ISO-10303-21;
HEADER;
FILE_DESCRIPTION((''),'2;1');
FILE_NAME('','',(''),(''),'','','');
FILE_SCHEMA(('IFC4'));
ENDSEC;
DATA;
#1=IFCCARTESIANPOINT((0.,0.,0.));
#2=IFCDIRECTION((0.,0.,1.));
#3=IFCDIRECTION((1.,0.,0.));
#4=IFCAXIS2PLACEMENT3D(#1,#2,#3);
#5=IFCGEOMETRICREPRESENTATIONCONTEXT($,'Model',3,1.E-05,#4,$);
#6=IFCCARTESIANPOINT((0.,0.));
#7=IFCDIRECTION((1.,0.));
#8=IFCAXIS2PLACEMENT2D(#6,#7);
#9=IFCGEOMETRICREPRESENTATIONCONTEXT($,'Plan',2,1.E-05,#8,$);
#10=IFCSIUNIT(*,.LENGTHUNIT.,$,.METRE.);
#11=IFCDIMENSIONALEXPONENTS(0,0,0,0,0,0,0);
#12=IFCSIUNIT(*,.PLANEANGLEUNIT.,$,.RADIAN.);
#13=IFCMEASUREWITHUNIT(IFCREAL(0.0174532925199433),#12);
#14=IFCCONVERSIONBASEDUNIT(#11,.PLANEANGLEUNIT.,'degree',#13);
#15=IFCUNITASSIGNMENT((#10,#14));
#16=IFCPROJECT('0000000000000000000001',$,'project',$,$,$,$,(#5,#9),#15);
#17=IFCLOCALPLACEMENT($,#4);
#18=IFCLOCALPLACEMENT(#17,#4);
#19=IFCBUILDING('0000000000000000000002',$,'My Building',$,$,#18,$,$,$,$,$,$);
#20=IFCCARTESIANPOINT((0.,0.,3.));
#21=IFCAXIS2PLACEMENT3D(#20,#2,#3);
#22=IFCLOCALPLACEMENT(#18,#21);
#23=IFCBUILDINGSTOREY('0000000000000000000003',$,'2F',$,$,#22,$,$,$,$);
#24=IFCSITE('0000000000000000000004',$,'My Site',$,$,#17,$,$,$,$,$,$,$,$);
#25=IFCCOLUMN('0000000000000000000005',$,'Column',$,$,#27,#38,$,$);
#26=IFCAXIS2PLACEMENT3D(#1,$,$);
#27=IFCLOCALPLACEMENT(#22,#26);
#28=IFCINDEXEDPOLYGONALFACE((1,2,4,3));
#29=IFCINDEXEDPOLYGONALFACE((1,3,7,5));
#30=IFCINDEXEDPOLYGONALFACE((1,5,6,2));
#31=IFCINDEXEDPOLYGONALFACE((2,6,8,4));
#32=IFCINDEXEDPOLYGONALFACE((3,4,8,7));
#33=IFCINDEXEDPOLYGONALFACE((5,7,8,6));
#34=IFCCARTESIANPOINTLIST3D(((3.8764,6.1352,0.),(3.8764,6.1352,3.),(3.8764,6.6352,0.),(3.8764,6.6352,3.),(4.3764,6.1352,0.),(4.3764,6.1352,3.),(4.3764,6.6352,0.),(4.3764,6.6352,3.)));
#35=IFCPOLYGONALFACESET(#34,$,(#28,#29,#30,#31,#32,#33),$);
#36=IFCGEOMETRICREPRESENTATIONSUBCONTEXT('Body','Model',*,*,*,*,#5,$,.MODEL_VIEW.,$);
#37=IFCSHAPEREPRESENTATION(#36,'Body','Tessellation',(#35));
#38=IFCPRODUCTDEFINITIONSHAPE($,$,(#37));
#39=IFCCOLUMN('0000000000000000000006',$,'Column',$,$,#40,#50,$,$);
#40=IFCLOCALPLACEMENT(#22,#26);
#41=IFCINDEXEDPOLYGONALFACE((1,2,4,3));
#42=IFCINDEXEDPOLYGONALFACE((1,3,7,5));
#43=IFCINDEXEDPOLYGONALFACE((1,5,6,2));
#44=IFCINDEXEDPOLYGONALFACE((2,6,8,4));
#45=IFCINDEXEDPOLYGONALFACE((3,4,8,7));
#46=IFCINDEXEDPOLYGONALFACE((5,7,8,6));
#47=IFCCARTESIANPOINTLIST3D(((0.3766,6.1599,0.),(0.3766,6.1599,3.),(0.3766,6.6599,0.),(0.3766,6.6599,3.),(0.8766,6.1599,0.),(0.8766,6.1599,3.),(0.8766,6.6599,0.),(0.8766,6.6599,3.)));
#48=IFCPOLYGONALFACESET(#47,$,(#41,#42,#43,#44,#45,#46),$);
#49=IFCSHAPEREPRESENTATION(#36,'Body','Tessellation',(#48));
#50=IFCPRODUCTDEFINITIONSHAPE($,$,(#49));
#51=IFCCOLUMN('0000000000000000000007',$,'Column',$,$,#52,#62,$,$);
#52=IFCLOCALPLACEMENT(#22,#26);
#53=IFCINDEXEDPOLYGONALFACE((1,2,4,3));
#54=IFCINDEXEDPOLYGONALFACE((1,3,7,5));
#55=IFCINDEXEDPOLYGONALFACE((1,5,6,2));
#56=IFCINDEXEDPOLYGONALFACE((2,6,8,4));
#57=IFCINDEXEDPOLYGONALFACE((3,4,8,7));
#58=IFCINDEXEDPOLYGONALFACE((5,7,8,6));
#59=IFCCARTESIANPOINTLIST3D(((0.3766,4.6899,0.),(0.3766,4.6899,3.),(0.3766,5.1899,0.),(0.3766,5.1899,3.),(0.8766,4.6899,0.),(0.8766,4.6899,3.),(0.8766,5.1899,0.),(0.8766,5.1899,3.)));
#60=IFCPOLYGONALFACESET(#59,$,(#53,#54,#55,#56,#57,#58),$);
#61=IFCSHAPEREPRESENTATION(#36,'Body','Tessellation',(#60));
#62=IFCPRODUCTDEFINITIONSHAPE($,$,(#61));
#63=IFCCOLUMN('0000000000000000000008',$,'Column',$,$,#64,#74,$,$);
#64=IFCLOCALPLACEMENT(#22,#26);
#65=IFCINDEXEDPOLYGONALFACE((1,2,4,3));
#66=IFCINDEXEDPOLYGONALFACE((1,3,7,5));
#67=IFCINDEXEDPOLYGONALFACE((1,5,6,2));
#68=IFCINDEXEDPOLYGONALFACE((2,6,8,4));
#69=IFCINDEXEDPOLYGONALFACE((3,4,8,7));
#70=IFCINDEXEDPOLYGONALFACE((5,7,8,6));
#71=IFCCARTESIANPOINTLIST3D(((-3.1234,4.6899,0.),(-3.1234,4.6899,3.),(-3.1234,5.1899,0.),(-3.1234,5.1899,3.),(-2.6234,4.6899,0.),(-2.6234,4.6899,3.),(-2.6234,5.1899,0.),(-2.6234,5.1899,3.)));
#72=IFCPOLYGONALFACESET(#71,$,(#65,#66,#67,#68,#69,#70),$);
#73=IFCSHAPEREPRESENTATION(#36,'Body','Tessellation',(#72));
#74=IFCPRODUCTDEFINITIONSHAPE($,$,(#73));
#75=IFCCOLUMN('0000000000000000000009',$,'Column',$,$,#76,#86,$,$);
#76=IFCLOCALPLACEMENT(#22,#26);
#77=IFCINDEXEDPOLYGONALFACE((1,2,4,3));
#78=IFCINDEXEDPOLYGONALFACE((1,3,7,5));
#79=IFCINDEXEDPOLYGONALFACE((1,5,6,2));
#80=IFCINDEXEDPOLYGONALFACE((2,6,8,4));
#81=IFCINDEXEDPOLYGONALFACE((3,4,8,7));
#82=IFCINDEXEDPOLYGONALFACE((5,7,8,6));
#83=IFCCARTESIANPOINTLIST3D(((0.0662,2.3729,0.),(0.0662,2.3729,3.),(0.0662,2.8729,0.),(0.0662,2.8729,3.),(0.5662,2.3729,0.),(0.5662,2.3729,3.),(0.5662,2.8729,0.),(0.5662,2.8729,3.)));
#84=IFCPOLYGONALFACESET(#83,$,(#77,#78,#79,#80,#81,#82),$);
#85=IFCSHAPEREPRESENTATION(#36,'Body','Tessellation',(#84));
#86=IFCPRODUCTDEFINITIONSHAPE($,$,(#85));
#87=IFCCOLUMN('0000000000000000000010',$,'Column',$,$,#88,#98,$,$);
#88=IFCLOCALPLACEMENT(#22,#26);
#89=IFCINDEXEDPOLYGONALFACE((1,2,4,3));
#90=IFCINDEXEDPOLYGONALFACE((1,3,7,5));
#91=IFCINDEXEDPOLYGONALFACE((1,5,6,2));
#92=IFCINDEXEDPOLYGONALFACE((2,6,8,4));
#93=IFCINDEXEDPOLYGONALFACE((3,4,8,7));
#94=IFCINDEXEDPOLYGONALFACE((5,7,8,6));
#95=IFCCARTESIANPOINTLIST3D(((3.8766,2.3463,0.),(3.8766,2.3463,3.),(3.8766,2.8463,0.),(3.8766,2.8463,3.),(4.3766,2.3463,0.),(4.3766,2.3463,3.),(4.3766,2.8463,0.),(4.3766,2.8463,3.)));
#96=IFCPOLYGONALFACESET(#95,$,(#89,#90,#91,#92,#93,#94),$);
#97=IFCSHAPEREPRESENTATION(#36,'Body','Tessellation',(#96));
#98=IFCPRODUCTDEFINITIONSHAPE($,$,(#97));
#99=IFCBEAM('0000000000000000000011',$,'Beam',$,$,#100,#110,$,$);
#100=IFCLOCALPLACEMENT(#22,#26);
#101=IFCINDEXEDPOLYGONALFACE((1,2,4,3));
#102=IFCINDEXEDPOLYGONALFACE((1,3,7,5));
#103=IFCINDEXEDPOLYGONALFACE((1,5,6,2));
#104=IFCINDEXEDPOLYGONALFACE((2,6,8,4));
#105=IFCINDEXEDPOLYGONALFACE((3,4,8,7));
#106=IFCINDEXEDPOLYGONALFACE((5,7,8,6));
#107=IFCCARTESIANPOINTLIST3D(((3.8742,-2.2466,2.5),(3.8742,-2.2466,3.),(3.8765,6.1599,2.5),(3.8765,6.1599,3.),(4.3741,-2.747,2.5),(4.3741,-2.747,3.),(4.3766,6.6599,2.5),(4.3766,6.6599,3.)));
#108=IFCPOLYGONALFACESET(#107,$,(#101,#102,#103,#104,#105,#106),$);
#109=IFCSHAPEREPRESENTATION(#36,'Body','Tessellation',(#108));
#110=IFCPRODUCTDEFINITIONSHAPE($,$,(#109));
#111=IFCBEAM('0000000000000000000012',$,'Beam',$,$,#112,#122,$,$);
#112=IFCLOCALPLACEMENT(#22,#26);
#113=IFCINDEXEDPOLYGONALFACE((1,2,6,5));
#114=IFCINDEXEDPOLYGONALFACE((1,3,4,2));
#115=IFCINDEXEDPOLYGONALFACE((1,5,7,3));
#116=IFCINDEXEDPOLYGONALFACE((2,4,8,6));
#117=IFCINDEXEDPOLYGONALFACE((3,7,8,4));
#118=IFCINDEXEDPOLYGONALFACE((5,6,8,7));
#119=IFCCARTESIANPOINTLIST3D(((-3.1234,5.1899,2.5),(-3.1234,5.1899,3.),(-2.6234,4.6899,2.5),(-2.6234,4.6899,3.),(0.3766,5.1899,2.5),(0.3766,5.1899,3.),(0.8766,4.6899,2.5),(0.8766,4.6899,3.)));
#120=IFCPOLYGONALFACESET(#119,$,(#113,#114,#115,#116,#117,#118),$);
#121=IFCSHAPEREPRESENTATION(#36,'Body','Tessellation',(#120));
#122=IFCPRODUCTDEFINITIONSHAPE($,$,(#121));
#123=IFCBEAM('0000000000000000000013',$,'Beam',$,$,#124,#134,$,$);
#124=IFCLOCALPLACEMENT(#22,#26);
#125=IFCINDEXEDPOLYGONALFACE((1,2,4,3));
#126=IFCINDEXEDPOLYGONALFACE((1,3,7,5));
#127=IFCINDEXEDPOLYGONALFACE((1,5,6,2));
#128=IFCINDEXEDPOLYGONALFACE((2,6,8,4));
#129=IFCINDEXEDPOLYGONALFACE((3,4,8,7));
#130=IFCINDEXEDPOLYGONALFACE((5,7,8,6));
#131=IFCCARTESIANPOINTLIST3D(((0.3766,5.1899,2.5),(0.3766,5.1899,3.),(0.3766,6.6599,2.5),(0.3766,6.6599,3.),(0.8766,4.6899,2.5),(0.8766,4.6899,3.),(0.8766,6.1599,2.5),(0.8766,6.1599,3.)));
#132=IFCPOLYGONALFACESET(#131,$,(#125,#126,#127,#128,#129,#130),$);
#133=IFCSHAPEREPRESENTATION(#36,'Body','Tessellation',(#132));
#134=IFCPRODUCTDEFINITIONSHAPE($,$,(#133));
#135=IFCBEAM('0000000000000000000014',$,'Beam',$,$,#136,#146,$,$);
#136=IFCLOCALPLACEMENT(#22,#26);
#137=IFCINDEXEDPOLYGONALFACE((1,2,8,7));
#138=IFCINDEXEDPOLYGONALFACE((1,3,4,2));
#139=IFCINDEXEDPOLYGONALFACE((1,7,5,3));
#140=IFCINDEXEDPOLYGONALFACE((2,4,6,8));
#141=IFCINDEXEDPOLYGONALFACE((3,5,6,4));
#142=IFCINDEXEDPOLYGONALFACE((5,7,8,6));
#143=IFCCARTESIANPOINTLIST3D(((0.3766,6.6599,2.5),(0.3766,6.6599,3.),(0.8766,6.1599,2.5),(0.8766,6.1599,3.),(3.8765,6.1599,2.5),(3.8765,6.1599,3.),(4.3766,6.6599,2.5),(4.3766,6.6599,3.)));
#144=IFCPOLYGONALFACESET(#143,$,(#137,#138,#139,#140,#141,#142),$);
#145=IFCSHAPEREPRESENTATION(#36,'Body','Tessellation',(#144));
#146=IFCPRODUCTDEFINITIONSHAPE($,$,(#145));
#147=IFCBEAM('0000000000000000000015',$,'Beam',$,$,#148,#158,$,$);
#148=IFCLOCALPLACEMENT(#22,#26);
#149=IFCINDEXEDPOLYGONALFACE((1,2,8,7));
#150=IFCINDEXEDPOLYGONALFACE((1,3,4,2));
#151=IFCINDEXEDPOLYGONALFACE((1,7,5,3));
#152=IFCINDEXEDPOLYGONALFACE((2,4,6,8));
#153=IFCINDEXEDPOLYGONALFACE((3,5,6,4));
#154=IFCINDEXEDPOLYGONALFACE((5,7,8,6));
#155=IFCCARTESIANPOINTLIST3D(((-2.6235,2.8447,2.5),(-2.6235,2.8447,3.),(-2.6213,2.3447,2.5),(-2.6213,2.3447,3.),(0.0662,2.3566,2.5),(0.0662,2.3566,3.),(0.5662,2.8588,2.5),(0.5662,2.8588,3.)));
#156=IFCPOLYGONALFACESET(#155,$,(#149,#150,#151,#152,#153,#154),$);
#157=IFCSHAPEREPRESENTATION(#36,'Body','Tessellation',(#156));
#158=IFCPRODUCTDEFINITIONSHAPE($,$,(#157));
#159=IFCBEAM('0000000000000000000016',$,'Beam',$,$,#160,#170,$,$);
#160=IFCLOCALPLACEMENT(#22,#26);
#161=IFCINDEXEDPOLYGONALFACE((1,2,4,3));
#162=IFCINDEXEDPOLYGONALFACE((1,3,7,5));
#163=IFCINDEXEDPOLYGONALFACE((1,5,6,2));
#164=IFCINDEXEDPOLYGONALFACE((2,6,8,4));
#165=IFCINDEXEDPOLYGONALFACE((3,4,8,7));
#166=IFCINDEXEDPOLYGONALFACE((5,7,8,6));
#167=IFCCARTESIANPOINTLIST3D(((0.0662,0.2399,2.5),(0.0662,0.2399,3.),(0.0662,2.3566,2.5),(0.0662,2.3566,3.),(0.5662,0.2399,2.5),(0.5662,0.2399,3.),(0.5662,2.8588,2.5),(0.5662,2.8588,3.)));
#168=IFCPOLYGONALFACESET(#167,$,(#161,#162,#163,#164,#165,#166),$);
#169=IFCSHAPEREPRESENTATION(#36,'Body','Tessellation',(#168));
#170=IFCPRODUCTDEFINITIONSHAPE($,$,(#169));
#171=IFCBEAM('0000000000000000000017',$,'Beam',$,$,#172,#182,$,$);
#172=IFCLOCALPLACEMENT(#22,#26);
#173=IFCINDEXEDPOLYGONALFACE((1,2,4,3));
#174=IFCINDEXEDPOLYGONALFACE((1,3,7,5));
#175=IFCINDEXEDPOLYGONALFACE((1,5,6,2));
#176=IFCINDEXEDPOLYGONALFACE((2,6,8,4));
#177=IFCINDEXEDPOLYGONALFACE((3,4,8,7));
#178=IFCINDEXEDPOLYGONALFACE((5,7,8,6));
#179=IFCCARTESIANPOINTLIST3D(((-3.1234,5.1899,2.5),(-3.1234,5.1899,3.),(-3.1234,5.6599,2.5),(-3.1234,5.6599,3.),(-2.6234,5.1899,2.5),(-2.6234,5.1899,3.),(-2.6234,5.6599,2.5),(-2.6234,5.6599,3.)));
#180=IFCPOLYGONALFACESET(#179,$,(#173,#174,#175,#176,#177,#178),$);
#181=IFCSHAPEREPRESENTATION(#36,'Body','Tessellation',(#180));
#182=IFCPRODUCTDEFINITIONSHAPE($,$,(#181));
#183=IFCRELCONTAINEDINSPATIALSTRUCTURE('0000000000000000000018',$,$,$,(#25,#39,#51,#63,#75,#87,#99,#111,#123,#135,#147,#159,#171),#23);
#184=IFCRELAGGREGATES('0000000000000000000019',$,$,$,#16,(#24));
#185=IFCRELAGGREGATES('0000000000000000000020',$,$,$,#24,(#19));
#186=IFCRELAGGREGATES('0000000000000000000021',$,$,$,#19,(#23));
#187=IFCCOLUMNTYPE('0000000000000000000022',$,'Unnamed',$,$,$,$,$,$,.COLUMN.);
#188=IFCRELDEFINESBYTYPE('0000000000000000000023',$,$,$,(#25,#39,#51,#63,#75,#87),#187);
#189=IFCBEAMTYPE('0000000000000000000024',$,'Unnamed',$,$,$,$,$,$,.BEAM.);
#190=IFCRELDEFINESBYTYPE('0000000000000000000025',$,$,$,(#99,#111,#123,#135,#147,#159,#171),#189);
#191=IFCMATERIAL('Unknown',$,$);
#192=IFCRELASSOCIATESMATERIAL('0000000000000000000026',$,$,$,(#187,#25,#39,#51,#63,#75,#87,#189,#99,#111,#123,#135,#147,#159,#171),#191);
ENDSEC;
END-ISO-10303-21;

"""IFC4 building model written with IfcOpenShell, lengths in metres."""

from ifc_helpers import new_model, entity, si_unit, converted_unit, frame, origin_with_axes, origin_2d_with_axis, place, context, subcontext, project, spatial, rectangle, extrude, clip, halfspace, material, material_profile, profile_set, profile_usage, type_object, element, save


model = new_model("IFC4")

# Units and contexts
model_context = context("Model", 3, precision=1e-05, world=origin_with_axes())
plan_context = context("Plan", 2, precision=1e-05, world=origin_2d_with_axis())
body_context_1 = subcontext(model_context, "Body", "Model", "MODEL_VIEW")
ifc_project = project(units=[si_unit("LENGTHUNIT", "METRE"), converted_unit("PLANEANGLEUNIT", "degree", entity("IfcReal", 0.0174532925199433), si_unit("PLANEANGLEUNIT", "RADIAN"), dimensions=[0, 0, 0, 0, 0, 0, 0])], contexts=[model_context, plan_context])

# Site, building, storey
site_placement = place(None, origin_with_axes())
site = spatial("IfcSite", under=ifc_project, at=site_placement, Name="My Site")
building_placement = place(site_placement, origin_with_axes())
building = spatial("IfcBuilding", under=site, at=building_placement, Name="My Building")
storey_placement = place(building_placement, frame((0.0, 0.0, 3.0), z_axis=(0.0, 0.0, 1.0), x_axis=(1.0, 0.0, 0.0)))
storey = spatial("IfcBuildingStorey", under=building, at=storey_placement, Name="2F")

# Columns
ifc_material = material(Name="Unknown")
ifc_material_profile_1 = material_profile(ifc_material, rectangle(XDim=0.5, YDim=0.5))
ifc_profile_set_1 = profile_set([ifc_material_profile_1])
ifc_profile_usage_1 = profile_usage(ifc_profile_set_1, cardinal=1)
column_type = type_object("IfcColumnType", Name="Unnamed", PredefinedType="COLUMN", material=ifc_profile_set_1)
column_1_placement = place(storey_placement, frame((4.3764, 6.1352, 0.0), z_axis=(0.0, 0.0, 1.0), x_axis=(1.0, 0.0, 0.0)))
element("IfcColumn", 1, at=column_1_placement, inside=storey, type_object=column_type, material=ifc_profile_usage_1, Name="Column", context=body_context_1, shape_type="SweptSolid", body=[
    extrude(rectangle(XDim=0.5, YDim=0.5), frame((-0.25, 0.25, 0.0), z_axis=(0.0, 0.0, 1.0), x_axis=(1.0, 0.0, 0.0)), (0.0, 0.0, 1.0), 3.0),
])
ifc_profile_usage_2 = profile_usage(ifc_profile_set_1, cardinal=1)
column_2_placement = place(storey_placement, frame((0.8766, 6.1599, 0.0), z_axis=(0.0, 0.0, 1.0), x_axis=(1.0, 0.0, 0.0)))
element("IfcColumn", 2, at=column_2_placement, inside=storey, type_object=column_type, material=ifc_profile_usage_2, Name="Column", context=body_context_1, shape_type="SweptSolid", body=[
    extrude(rectangle(XDim=0.5, YDim=0.5), frame((-0.25, 0.25, 0.0), z_axis=(0.0, 0.0, 1.0), x_axis=(1.0, 0.0, 0.0)), (0.0, 0.0, 1.0), 3.0),
])
ifc_profile_usage_3 = profile_usage(ifc_profile_set_1, cardinal=1)
column_3_placement = place(storey_placement, frame((0.8766, 4.6899, 0.0), z_axis=(0.0, 0.0, 1.0), x_axis=(1.0, 0.0, 0.0)))
element("IfcColumn", 3, at=column_3_placement, inside=storey, type_object=column_type, material=ifc_profile_usage_3, Name="Column", context=body_context_1, shape_type="SweptSolid", body=[
    extrude(rectangle(XDim=0.5, YDim=0.5), frame((-0.25, 0.25, 0.0), z_axis=(0.0, 0.0, 1.0), x_axis=(1.0, 0.0, 0.0)), (0.0, 0.0, 1.0), 3.0),
])
ifc_profile_usage_4 = profile_usage(ifc_profile_set_1, cardinal=1)
column_4_placement = place(storey_placement, frame((-2.6234, 4.6899, 0.0), z_axis=(0.0, 0.0, 1.0), x_axis=(1.0, 0.0, 0.0)))
element("IfcColumn", 4, at=column_4_placement, inside=storey, type_object=column_type, material=ifc_profile_usage_4, Name="Column", context=body_context_1, shape_type="SweptSolid", body=[
    extrude(rectangle(XDim=0.5, YDim=0.5), frame((-0.25, 0.25, 0.0), z_axis=(0.0, 0.0, 1.0), x_axis=(1.0, 0.0, 0.0)), (0.0, 0.0, 1.0), 3.0),
])
ifc_profile_usage_5 = profile_usage(ifc_profile_set_1, cardinal=1)
column_5_placement = place(storey_placement, frame((0.5662, 2.3729, 0.0), z_axis=(0.0, 0.0, 1.0), x_axis=(1.0, 0.0, 0.0)))
element("IfcColumn", 5, at=column_5_placement, inside=storey, type_object=column_type, material=ifc_profile_usage_5, Name="Column", context=body_context_1, shape_type="SweptSolid", body=[
    extrude(rectangle(XDim=0.5, YDim=0.5), frame((-0.25, 0.25, 0.0), z_axis=(0.0, 0.0, 1.0), x_axis=(1.0, 0.0, 0.0)), (0.0, 0.0, 1.0), 3.0),
])
ifc_profile_usage_6 = profile_usage(ifc_profile_set_1, cardinal=1)
column_6_placement = place(storey_placement, frame((4.3766, 2.3463, 0.0), z_axis=(0.0, 0.0, 1.0), x_axis=(1.0, 0.0, 0.0)))
element("IfcColumn", 6, at=column_6_placement, inside=storey, type_object=column_type, material=ifc_profile_usage_6, Name="Column", context=body_context_1, shape_type="SweptSolid", body=[
    extrude(rectangle(XDim=0.5, YDim=0.5), frame((-0.25, 0.25, 0.0), z_axis=(0.0, 0.0, 1.0), x_axis=(1.0, 0.0, 0.0)), (0.0, 0.0, 1.0), 3.0),
])

# Beams
ifc_material_profile_2 = material_profile(ifc_material, rectangle(XDim=0.5, YDim=0.5))
ifc_profile_set_2 = profile_set([ifc_material_profile_2])
ifc_profile_usage_7 = profile_usage(ifc_profile_set_2, cardinal=7)
beam_type = type_object("IfcBeamType", Name="Unnamed", PredefinedType="BEAM", material=ifc_profile_set_2)
beam_1_placement = place(storey_placement, frame((4.3767, 7.1599, 3.0), z_axis=(-0.000268, -1.0, 0.0), x_axis=(1.0, -0.000268, 0.0)))
element("IfcBeam", 7, at=beam_1_placement, inside=storey, type_object=beam_type, material=ifc_profile_usage_7, Name="Beam", context=body_context_1, shape_type="Clipping", body=[
    clip(clip(extrude(rectangle(XDim=0.5, YDim=0.5), frame((-0.25, -0.25, 0.0), z_axis=(0.0, 0.0, 1.0), x_axis=(1.0, 0.0, 0.0)), (0.0, 0.0, 1.0), 10.4069), halfspace(frame((0.0, -6.0, 9.9069), z_axis=(-0.707281, 0.0, 0.706933), x_axis=(0.0, 1.0, 0.0)), False)), halfspace(frame((0.0, -6.0, 0.5), z_axis=(-0.707201, 0.0, -0.707012), x_axis=(0.0, 1.0, 0.0)), False)),
])
ifc_profile_usage_8 = profile_usage(ifc_profile_set_2, cardinal=7)
beam_2_placement = place(storey_placement, frame((-3.1234, 5.1899, 3.0), z_axis=(1.0, 0.0, 0.0), x_axis=(0.0, 1.0, 0.0)))
element("IfcBeam", 8, at=beam_2_placement, inside=storey, type_object=beam_type, material=ifc_profile_usage_8, Name="Beam", context=body_context_1, shape_type="Clipping", body=[
    clip(clip(extrude(rectangle(XDim=0.5, YDim=0.5), frame((-0.25, -0.25, 0.0), z_axis=(0.0, 0.0, 1.0), x_axis=(1.0, 0.0, 0.0)), (0.0, 0.0, 1.0), 4.0), halfspace(frame((-0.5, -6.0, 4.0), z_axis=(0.707107, 0.0, 0.707107), x_axis=(0.0, -1.0, 0.0)), False)), halfspace(frame((0.0, -6.0, 0.0), z_axis=(-0.707107, 0.0, -0.707106), x_axis=(0.0, 1.0, 0.0)), False)),
])
ifc_profile_usage_9 = profile_usage(ifc_profile_set_2, cardinal=7)
beam_3_placement = place(storey_placement, frame((0.3766, 4.6899, 3.0), z_axis=(0.0, 1.0, 0.0), x_axis=(-1.0, 0.0, 0.0)))
element("IfcBeam", 9, at=beam_3_placement, inside=storey, type_object=beam_type, material=ifc_profile_usage_9, Name="Beam", context=body_context_1, shape_type="Clipping", body=[
    clip(clip(extrude(rectangle(XDim=0.5, YDim=0.5), frame((-0.25, -0.25, 0.0), z_axis=(0.0, 0.0, 1.0), x_axis=(1.0, 0.0, 0.0)), (0.0, 0.0, 1.0), 1.97), halfspace(frame((0.0, -6.0, 1.97), z_axis=(-0.707107, 0.0, 0.707106), x_axis=(0.0, 1.0, 0.0)), False)), halfspace(frame((-0.5, -6.0, 0.0), z_axis=(0.707107, 0.0, -0.707106), x_axis=(0.0, -1.0, 0.0)), False)),
])
ifc_profile_usage_10 = profile_usage(ifc_profile_set_2, cardinal=7)
beam_4_placement = place(storey_placement, frame((0.3766, 6.6599, 3.0), z_axis=(1.0, 0.0, 0.0), x_axis=(0.0, 1.0, 0.0)))
element("IfcBeam", 10, at=beam_4_placement, inside=storey, type_object=beam_type, material=ifc_profile_usage_10, Name="Beam", context=body_context_1, shape_type="Clipping", body=[
    clip(clip(extrude(rectangle(XDim=0.5, YDim=0.5), frame((-0.25, -0.25, 0.0), z_axis=(0.0, 0.0, 1.0), x_axis=(1.0, 0.0, 0.0)), (0.0, 0.0, 1.0), 4.5), halfspace(frame((0.0, -6.0, 4.0), z_axis=(-0.707202, 0.0, 0.707012), x_axis=(0.0, 1.0, 0.0)), False)), halfspace(frame((0.0, -6.0, 0.0), z_axis=(-0.707107, 0.0, -0.707107), x_axis=(0.0, 1.0, 0.0)), False)),
])
ifc_profile_usage_11 = profile_usage(ifc_profile_set_2, cardinal=7)
beam_5_placement = place(storey_placement, frame((-2.6235, 2.8447, 3.0), z_axis=(0.99999, 0.004431, 0.0), x_axis=(-0.004431, 0.99999, 0.0)))
element("IfcBeam", 11, at=beam_5_placement, inside=storey, type_object=beam_type, material=ifc_profile_usage_11, Name="Beam", context=body_context_1, shape_type="Clipping", body=[
    clip(extrude(rectangle(XDim=0.5, YDim=0.5), frame((-0.25, -0.25, 0.0), z_axis=(0.0, 0.0, 1.0), x_axis=(1.0, 0.0, 0.0)), (0.0, 0.0, 1.0), 3.6897), halfspace(frame((0.0, -6.0, 3.1897), z_axis=(-0.708672, 0.0, 0.705539), x_axis=(0.0, 1.0, 0.0)), False)),
])
ifc_profile_usage_12 = profile_usage(ifc_profile_set_2, cardinal=7)
beam_6_placement = place(storey_placement, frame((0.5662, 3.3588, 3.0), z_axis=(0.0, -1.0, 0.0), x_axis=(1.0, 0.0, 0.0)))
element("IfcBeam", 12, at=beam_6_placement, inside=storey, type_object=beam_type, material=ifc_profile_usage_12, Name="Beam", context=body_context_1, shape_type="Clipping", body=[
    clip(extrude(rectangle(XDim=0.5, YDim=0.5), frame((-0.25, -0.25, 0.0), z_axis=(0.0, 0.0, 1.0), x_axis=(1.0, 0.0, 0.0)), (0.0, 0.0, 1.0), 3.1189), halfspace(frame((0.0, -6.0, 0.5), z_axis=(-0.708672, 0.0, -0.705538), x_axis=(0.0, 1.0, 0.0)), False)),
])
ifc_profile_usage_13 = profile_usage(ifc_profile_set_2, cardinal=7)
beam_7_placement = place(storey_placement, frame((-3.1234, 5.1899, 3.0), z_axis=(0.0, 1.0, -0.000001), x_axis=(-1.0, 0.0, 0.0)))
element("IfcBeam", 13, at=beam_7_placement, inside=storey, type_object=beam_type, material=ifc_profile_usage_13, Name="Beam", context=body_context_1, shape_type="SweptSolid", body=[
    extrude(rectangle(XDim=0.5, YDim=0.5), frame((-0.25, -0.25, 0.0), z_axis=(0.0, 0.0, 1.0), x_axis=(1.0, 0.0, 0.0)), (0.0, 0.0, 1.0), 0.47),
])

save(model, "model.ifc")
